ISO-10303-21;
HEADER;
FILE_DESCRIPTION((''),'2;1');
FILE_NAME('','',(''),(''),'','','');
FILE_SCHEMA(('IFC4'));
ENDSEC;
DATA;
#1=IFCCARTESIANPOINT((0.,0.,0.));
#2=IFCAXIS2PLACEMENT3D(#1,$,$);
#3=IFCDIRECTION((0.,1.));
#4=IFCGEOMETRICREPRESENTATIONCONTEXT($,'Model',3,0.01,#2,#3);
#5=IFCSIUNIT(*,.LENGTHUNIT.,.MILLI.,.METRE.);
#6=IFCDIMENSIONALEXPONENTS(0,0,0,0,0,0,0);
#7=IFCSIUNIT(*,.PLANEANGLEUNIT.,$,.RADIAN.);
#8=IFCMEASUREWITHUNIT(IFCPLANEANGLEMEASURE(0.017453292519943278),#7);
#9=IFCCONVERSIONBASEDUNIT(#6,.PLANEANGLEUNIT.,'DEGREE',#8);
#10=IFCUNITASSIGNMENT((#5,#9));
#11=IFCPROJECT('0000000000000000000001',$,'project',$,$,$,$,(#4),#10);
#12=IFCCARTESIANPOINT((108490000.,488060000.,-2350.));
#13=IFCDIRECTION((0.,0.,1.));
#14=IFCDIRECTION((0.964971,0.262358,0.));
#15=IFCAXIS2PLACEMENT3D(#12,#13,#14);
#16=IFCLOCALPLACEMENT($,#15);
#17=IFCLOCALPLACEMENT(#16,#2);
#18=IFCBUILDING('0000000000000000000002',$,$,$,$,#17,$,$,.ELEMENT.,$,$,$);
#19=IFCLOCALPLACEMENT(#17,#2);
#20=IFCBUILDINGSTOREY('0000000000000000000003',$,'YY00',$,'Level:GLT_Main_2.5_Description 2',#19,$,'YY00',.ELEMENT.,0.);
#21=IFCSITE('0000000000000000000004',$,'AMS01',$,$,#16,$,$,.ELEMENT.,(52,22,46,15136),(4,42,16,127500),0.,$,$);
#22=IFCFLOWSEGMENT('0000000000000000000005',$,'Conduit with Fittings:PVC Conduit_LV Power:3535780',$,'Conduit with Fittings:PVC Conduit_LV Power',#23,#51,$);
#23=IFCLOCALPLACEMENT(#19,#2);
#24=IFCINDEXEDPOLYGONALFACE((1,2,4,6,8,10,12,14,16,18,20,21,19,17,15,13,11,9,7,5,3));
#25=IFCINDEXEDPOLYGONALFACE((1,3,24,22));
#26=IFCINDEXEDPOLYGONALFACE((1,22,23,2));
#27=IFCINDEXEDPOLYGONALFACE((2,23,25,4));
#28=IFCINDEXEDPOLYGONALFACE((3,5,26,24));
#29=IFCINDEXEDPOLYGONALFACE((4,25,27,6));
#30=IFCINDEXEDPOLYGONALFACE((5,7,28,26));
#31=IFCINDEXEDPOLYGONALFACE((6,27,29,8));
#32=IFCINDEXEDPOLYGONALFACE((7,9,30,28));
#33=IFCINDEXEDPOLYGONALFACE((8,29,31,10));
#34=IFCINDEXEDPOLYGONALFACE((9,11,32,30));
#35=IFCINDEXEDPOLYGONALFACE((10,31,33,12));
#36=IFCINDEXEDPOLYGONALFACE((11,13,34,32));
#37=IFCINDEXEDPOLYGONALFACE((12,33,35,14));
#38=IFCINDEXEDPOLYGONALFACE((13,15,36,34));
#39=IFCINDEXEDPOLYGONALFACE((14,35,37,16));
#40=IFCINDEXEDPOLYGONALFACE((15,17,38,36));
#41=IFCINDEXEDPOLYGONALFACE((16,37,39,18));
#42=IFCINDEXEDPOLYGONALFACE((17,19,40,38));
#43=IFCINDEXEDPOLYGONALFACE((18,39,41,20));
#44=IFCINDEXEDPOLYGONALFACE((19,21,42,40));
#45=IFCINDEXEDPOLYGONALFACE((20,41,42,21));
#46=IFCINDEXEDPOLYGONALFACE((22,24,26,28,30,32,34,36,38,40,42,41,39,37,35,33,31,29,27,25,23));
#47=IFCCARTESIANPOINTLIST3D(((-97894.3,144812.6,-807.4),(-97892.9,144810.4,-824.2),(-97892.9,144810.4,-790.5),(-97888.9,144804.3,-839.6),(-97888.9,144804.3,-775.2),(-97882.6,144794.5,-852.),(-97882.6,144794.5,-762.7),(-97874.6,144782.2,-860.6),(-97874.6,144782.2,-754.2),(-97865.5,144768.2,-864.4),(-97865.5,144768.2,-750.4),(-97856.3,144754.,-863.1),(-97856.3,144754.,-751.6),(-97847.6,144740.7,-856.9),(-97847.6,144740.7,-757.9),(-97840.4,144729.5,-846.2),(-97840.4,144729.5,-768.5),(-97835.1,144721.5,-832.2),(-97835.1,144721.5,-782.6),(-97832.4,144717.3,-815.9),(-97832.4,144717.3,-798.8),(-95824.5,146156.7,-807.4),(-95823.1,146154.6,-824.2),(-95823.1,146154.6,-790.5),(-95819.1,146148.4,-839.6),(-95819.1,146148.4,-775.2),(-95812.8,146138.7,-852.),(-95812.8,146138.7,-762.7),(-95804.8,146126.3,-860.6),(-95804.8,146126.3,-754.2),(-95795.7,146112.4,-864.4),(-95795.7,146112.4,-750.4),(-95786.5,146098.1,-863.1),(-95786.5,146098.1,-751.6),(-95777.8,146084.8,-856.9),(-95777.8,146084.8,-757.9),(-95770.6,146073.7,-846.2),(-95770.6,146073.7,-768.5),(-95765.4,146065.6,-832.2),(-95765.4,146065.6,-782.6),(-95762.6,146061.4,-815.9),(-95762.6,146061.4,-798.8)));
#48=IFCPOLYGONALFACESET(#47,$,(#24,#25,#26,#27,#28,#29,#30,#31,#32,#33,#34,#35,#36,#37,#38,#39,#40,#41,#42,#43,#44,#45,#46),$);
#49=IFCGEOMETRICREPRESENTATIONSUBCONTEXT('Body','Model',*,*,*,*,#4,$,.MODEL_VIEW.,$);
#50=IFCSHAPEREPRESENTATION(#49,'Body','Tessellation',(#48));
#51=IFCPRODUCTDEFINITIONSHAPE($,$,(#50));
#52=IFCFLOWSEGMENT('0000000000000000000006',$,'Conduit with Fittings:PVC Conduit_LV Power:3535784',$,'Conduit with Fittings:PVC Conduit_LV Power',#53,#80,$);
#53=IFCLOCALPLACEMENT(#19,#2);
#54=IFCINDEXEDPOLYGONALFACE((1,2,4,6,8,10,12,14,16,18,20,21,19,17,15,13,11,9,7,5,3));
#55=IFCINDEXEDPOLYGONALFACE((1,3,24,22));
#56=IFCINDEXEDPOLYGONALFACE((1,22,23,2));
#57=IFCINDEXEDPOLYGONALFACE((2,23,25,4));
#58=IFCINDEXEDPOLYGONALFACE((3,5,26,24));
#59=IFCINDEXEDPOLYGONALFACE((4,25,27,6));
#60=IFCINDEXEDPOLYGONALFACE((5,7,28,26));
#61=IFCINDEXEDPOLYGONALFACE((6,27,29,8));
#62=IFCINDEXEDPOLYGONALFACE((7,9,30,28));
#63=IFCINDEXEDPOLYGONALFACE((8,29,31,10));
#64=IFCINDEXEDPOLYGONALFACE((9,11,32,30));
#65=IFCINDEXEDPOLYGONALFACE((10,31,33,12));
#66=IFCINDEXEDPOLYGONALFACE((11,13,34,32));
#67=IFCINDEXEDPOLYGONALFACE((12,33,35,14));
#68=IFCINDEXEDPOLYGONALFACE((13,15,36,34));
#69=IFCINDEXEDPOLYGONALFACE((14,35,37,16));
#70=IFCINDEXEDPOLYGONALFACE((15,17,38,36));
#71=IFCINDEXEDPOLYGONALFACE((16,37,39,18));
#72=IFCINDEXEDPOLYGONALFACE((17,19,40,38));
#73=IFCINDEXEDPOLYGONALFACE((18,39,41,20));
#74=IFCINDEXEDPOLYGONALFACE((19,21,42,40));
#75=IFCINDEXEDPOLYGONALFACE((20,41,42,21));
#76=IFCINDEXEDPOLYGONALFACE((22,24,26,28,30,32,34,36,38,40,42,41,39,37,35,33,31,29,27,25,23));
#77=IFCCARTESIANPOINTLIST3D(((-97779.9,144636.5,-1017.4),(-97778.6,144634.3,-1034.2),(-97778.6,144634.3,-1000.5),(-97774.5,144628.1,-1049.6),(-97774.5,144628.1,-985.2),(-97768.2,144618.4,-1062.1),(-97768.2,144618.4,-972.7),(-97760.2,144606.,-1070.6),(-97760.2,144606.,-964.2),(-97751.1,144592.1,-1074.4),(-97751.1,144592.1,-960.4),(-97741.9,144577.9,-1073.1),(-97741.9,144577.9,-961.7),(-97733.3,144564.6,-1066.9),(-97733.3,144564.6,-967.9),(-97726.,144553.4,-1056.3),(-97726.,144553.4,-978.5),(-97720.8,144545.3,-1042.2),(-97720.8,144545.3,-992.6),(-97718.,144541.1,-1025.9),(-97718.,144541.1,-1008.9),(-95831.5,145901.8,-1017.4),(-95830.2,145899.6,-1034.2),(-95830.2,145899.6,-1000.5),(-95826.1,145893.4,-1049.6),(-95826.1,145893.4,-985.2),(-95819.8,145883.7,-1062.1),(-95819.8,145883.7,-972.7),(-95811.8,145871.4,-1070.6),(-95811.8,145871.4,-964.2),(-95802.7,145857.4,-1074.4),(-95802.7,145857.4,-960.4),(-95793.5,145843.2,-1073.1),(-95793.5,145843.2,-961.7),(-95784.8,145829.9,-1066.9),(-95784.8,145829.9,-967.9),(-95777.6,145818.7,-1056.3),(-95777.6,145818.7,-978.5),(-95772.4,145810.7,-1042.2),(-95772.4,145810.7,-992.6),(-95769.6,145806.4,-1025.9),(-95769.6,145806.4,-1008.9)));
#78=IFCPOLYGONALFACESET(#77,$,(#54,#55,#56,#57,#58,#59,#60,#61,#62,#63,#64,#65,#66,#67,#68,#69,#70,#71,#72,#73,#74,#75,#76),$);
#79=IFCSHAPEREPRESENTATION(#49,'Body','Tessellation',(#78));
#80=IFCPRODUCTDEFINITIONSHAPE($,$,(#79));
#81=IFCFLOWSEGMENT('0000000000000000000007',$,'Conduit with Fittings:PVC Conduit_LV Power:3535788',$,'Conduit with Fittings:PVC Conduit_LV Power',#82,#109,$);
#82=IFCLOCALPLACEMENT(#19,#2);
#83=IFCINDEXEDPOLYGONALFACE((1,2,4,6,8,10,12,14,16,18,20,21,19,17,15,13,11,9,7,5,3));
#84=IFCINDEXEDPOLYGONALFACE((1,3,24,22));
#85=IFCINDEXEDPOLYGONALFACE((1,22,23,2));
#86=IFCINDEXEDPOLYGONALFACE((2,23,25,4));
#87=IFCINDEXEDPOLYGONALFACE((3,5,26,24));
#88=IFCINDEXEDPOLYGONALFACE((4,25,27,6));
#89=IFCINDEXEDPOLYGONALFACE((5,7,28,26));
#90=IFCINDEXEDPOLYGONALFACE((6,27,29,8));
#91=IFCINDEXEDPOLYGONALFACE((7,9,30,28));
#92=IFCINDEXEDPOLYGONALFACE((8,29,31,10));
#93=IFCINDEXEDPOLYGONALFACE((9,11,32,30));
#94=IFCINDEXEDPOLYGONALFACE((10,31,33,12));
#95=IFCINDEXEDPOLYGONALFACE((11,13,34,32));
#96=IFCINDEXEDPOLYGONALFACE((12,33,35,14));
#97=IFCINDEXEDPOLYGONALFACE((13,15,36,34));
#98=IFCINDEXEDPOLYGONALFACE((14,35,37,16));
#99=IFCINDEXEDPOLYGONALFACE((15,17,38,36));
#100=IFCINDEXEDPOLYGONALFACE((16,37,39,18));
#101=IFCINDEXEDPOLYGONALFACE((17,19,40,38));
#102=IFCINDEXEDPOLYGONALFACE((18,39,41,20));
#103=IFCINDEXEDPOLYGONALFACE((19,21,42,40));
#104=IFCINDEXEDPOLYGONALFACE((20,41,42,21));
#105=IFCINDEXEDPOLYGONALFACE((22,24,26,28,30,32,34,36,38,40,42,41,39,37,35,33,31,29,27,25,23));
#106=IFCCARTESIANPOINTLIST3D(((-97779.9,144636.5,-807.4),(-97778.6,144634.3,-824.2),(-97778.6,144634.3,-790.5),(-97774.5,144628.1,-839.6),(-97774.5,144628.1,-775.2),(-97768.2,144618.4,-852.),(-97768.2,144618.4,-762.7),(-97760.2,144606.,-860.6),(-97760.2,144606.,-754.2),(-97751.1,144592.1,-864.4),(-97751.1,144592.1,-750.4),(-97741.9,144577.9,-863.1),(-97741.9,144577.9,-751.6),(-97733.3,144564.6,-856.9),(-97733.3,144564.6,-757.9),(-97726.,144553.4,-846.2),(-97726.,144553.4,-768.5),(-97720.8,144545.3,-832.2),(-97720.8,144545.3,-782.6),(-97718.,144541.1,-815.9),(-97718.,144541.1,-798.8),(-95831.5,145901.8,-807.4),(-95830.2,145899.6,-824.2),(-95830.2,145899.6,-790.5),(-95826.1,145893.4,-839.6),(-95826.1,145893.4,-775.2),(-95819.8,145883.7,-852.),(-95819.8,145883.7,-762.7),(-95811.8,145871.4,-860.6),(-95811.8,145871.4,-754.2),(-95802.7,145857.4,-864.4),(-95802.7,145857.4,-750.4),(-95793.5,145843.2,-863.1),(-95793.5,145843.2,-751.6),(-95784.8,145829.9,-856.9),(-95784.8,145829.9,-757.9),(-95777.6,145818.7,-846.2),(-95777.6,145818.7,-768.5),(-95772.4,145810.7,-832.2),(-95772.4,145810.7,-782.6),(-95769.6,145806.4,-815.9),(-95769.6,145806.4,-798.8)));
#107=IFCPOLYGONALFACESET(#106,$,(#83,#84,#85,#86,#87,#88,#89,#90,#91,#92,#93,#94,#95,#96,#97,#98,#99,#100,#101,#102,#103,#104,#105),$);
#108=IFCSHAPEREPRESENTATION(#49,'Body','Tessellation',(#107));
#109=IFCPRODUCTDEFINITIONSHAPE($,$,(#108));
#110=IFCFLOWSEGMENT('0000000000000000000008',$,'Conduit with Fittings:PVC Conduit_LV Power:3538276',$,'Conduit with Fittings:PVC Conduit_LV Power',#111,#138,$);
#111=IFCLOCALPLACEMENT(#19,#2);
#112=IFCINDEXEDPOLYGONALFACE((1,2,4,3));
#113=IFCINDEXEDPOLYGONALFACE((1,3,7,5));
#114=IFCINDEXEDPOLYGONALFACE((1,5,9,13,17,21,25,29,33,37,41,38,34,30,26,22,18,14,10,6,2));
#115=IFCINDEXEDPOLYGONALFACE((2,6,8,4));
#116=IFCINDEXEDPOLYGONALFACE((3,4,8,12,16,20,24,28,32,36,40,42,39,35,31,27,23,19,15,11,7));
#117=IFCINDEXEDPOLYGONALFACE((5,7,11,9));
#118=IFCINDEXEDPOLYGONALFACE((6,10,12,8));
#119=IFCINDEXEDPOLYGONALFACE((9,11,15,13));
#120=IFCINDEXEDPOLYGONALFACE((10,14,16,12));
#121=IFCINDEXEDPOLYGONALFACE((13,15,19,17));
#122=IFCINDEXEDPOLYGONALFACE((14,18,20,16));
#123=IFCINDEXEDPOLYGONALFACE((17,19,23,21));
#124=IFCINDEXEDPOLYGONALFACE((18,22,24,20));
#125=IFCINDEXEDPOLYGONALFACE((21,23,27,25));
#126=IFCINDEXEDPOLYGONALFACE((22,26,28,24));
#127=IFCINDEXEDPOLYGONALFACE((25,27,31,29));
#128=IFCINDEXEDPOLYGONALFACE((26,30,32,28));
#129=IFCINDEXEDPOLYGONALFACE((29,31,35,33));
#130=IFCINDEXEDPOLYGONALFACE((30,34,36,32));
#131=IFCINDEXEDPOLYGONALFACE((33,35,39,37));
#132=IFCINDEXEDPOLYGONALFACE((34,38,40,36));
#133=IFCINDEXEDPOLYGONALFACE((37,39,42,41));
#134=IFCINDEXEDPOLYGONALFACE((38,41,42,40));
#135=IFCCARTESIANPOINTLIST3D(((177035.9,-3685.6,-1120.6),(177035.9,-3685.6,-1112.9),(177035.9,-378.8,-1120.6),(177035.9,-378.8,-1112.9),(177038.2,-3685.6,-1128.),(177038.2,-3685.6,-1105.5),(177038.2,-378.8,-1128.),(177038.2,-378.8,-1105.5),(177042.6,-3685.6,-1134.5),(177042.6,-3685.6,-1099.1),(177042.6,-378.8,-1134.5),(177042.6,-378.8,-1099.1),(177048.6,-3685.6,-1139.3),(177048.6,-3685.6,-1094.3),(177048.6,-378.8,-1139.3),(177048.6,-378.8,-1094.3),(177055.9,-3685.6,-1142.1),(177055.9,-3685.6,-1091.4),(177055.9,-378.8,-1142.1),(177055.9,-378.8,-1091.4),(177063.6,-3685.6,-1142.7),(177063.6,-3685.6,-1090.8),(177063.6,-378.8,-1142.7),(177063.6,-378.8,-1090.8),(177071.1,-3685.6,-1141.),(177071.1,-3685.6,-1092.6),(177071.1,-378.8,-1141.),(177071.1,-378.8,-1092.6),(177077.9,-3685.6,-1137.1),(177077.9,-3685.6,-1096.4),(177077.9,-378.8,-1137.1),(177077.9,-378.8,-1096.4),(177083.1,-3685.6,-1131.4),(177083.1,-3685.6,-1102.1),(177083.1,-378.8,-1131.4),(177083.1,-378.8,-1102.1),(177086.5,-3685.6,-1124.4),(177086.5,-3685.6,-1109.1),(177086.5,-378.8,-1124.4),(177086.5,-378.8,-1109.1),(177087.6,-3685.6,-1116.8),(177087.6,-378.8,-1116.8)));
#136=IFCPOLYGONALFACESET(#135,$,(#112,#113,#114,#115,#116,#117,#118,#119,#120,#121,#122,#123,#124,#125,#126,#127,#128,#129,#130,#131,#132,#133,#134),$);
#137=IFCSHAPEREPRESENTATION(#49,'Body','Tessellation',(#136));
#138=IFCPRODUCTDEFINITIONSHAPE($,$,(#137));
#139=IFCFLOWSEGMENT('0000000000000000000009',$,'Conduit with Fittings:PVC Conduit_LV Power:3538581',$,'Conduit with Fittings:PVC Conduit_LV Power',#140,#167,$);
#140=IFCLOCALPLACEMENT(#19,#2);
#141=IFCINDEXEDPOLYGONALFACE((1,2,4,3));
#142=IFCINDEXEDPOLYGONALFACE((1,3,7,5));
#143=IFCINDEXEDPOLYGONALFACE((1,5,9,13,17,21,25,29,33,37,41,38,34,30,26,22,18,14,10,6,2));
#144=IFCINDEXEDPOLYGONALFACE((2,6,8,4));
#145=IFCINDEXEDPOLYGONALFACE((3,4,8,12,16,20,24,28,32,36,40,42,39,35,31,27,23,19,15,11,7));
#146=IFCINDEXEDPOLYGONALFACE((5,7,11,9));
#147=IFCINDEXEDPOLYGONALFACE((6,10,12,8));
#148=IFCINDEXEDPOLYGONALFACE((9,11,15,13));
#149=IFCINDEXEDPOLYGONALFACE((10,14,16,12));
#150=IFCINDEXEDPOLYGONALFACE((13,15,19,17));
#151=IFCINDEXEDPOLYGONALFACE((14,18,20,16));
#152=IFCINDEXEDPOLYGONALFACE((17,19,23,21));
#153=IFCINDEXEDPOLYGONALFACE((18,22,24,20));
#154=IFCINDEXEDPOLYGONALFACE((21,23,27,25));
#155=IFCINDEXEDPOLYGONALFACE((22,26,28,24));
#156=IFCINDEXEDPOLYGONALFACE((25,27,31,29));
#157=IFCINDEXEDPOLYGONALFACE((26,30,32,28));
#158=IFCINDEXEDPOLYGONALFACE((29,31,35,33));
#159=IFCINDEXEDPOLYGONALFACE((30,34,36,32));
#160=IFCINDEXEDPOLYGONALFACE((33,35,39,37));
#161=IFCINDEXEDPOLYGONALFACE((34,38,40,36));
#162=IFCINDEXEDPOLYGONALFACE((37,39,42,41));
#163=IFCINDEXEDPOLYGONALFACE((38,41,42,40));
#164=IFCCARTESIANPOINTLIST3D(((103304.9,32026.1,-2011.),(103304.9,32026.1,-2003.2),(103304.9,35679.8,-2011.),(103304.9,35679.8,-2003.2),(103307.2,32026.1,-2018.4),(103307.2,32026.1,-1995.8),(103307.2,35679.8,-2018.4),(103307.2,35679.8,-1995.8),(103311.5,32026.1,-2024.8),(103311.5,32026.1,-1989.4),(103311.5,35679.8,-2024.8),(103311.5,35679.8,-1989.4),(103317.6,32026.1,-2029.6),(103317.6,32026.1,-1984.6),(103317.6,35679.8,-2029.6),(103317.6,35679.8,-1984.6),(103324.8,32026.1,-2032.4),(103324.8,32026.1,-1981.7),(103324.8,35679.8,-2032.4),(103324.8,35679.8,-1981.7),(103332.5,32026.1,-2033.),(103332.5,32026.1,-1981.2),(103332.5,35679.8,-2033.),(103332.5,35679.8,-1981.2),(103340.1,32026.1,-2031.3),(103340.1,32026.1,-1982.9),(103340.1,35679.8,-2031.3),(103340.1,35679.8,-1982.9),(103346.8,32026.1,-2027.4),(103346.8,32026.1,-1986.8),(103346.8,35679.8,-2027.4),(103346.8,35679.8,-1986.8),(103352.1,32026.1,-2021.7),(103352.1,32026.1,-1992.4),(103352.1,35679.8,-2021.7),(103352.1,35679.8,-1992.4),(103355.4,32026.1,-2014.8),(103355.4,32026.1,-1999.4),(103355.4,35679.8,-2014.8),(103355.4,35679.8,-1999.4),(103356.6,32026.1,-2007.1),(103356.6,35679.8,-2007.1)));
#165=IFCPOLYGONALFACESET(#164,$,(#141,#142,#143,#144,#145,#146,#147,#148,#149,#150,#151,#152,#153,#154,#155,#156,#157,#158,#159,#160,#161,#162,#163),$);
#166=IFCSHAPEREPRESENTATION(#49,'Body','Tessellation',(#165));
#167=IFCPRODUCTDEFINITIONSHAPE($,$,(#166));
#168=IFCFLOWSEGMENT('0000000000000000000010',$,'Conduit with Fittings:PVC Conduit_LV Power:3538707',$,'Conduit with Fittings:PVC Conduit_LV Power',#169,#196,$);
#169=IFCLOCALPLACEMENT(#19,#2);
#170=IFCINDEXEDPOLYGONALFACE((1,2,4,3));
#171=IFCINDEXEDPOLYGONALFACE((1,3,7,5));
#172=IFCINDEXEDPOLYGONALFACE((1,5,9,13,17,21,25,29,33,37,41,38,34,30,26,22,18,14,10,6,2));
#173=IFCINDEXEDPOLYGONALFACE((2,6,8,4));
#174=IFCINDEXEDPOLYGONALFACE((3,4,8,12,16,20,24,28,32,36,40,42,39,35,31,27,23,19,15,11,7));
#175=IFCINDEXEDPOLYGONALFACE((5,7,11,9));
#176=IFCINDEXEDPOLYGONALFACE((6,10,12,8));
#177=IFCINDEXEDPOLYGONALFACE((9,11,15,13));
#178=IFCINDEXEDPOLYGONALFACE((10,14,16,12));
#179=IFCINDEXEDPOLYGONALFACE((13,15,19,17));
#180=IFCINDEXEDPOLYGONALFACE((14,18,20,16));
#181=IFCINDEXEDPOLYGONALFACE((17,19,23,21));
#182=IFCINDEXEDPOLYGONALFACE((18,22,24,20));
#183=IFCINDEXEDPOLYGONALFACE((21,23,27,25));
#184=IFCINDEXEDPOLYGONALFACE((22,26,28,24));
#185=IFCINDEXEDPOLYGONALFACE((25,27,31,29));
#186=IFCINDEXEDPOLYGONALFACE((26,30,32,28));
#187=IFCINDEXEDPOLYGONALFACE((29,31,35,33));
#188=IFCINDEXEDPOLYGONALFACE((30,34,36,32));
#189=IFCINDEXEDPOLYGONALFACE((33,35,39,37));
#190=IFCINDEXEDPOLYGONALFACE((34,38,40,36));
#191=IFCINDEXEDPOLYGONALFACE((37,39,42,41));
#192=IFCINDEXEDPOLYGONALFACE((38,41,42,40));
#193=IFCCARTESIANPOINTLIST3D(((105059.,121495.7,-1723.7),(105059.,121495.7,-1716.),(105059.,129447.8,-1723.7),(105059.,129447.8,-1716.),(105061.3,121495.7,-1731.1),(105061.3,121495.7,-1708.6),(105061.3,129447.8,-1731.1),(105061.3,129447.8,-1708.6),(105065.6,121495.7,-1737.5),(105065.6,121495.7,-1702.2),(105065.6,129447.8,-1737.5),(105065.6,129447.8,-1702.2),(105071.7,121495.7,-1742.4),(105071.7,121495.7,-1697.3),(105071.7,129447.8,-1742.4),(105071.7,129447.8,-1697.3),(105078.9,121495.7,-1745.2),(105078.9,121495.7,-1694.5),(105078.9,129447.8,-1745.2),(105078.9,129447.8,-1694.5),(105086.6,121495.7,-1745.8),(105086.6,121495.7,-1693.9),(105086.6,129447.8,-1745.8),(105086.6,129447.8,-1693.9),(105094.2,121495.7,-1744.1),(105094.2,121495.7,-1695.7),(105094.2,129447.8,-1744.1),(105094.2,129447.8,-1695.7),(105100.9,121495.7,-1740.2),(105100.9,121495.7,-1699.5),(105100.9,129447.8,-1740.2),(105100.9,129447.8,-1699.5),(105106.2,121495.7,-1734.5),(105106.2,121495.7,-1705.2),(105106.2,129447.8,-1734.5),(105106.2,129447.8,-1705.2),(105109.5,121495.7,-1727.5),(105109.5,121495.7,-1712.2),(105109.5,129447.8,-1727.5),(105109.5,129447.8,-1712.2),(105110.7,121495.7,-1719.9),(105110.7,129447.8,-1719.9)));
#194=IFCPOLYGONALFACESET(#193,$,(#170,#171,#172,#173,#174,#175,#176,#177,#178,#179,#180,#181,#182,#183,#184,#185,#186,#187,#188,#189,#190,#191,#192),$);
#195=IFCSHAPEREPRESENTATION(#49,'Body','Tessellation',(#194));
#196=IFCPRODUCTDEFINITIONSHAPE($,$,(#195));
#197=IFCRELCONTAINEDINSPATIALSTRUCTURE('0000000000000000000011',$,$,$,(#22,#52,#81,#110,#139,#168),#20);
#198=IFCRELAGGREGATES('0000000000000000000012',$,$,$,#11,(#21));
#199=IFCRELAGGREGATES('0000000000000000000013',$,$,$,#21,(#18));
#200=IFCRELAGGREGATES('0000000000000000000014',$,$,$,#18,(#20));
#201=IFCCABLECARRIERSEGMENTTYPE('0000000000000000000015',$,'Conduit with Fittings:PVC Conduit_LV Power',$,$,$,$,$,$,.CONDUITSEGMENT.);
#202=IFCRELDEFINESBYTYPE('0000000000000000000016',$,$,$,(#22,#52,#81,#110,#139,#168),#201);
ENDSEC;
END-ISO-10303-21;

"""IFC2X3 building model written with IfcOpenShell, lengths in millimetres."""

from ifc_helpers import new_model, entity, si_unit, converted_unit, direction, frame, origin, origin_2d_with_axis, place, context, subcontext, project, spatial, circle, extrude, type_object, element, save


model = new_model("IFC2X3")

# Units and contexts
model_context = context("Model", 3, precision=0.01, world=origin(), true_north=direction((0.0, 1.0)))
body_context = subcontext(model_context, "Body", "Model", "MODEL_VIEW")
ifc_project = project(units=[si_unit("LENGTHUNIT", "METRE", prefix="MILLI"), converted_unit("PLANEANGLEUNIT", "DEGREE", entity("IfcPlaneAngleMeasure", 0.017453292519943278), si_unit("PLANEANGLEUNIT", "RADIAN"), dimensions=[0, 0, 0, 0, 0, 0, 0])], contexts=[model_context])

# Site, building, storey
site_placement = place(None, frame((108490000.0, 488060000.0, -2350.0), z_axis=(0.0, 0.0, 1.0), x_axis=(0.964971, 0.262358, 0.0)))
site = spatial("IfcSite", under=ifc_project, at=site_placement, Name="AMS01", CompositionType="ELEMENT", RefLatitude=(52, 22, 46, 15136), RefLongitude=(4, 42, 16, 127500), RefElevation=0.0)
building_placement = place(site_placement, origin())
building = spatial("IfcBuilding", under=site, at=building_placement, CompositionType="ELEMENT")
storey_placement = place(building_placement, origin())
storey = spatial("IfcBuildingStorey", under=building, at=storey_placement, Name="YY00", ObjectType="Level:GLT_Main_2.5_Description 2", LongName="YY00", CompositionType="ELEMENT", Elevation=0.0)

# Flow segments
cable_carrier_segment_type = type_object("IfcCableCarrierSegmentType", Name="Conduit with Fittings:PVC Conduit_LV Power", PredefinedType="CONDUITSEGMENT")
flow_segment_1_placement = place(storey_placement, origin())
element("IfcFlowSegment", 1, at=flow_segment_1_placement, inside=storey, type_object=cable_carrier_segment_type, Name="Conduit with Fittings:PVC Conduit_LV Power:3535780", ObjectType="Conduit with Fittings:PVC Conduit_LV Power", context=body_context, shape_type="SweptSolid", body=[
    extrude(circle(Radius=57.2, at=origin_2d_with_axis()), frame((-97863.2, 144764.6, -807.4), z_axis=(0.838671, 0.544639, 0.0), x_axis=(-0.544639, 0.838671, 0.0)), (0.0, 0.0, 1.0), 2468.0),
])
flow_segment_2_placement = place(storey_placement, origin())
element("IfcFlowSegment", 2, at=flow_segment_2_placement, inside=storey, type_object=cable_carrier_segment_type, Name="Conduit with Fittings:PVC Conduit_LV Power:3535784", ObjectType="Conduit with Fittings:PVC Conduit_LV Power", context=body_context, shape_type="SweptSolid", body=[
    extrude(circle(Radius=57.2, at=origin_2d_with_axis()), frame((-97748.8, 144588.5, -1017.4), z_axis=(0.838671, 0.544639, 0.0), x_axis=(-0.544639, 0.838671, 0.0)), (0.0, 0.0, 1.0), 2323.2),
])
flow_segment_3_placement = place(storey_placement, origin())
element("IfcFlowSegment", 3, at=flow_segment_3_placement, inside=storey, type_object=cable_carrier_segment_type, Name="Conduit with Fittings:PVC Conduit_LV Power:3535788", ObjectType="Conduit with Fittings:PVC Conduit_LV Power", context=body_context, shape_type="SweptSolid", body=[
    extrude(circle(Radius=57.2, at=origin_2d_with_axis()), frame((-97748.8, 144588.5, -807.4), z_axis=(0.838671, 0.544639, 0.0), x_axis=(-0.544639, 0.838671, 0.0)), (0.0, 0.0, 1.0), 2323.2),
])
flow_segment_4_placement = place(storey_placement, origin())
element("IfcFlowSegment", 4, at=flow_segment_4_placement, inside=storey, type_object=cable_carrier_segment_type, Name="Conduit with Fittings:PVC Conduit_LV Power:3538276", ObjectType="Conduit with Fittings:PVC Conduit_LV Power", context=body_context, shape_type="SweptSolid", body=[
    extrude(circle(Radius=26.0, at=origin_2d_with_axis()), frame((177061.6, -3685.6, -1116.8), z_axis=(0.0, 1.0, 0.0), x_axis=(1.0, 0.0, 0.0)), (0.0, 0.0, 1.0), 3306.8),
])
flow_segment_5_placement = place(storey_placement, origin())
element("IfcFlowSegment", 5, at=flow_segment_5_placement, inside=storey, type_object=cable_carrier_segment_type, Name="Conduit with Fittings:PVC Conduit_LV Power:3538581", ObjectType="Conduit with Fittings:PVC Conduit_LV Power", context=body_context, shape_type="SweptSolid", body=[
    extrude(circle(Radius=26.0, at=origin_2d_with_axis()), frame((103330.6, 32026.1, -2007.1), z_axis=(0.0, 1.0, 0.0), x_axis=(1.0, 0.0, 0.0)), (0.0, 0.0, 1.0), 3653.7),
])
flow_segment_6_placement = place(storey_placement, origin())
element("IfcFlowSegment", 6, at=flow_segment_6_placement, inside=storey, type_object=cable_carrier_segment_type, Name="Conduit with Fittings:PVC Conduit_LV Power:3538707", ObjectType="Conduit with Fittings:PVC Conduit_LV Power", context=body_context, shape_type="SweptSolid", body=[
    extrude(circle(Radius=26.0, at=origin_2d_with_axis()), frame((105084.7, 121495.7, -1719.9), z_axis=(0.0, 1.0, 0.0), x_axis=(1.0, 0.0, 0.0)), (0.0, 0.0, 1.0), 7952.1),
])

save(model, "model.ifc")
